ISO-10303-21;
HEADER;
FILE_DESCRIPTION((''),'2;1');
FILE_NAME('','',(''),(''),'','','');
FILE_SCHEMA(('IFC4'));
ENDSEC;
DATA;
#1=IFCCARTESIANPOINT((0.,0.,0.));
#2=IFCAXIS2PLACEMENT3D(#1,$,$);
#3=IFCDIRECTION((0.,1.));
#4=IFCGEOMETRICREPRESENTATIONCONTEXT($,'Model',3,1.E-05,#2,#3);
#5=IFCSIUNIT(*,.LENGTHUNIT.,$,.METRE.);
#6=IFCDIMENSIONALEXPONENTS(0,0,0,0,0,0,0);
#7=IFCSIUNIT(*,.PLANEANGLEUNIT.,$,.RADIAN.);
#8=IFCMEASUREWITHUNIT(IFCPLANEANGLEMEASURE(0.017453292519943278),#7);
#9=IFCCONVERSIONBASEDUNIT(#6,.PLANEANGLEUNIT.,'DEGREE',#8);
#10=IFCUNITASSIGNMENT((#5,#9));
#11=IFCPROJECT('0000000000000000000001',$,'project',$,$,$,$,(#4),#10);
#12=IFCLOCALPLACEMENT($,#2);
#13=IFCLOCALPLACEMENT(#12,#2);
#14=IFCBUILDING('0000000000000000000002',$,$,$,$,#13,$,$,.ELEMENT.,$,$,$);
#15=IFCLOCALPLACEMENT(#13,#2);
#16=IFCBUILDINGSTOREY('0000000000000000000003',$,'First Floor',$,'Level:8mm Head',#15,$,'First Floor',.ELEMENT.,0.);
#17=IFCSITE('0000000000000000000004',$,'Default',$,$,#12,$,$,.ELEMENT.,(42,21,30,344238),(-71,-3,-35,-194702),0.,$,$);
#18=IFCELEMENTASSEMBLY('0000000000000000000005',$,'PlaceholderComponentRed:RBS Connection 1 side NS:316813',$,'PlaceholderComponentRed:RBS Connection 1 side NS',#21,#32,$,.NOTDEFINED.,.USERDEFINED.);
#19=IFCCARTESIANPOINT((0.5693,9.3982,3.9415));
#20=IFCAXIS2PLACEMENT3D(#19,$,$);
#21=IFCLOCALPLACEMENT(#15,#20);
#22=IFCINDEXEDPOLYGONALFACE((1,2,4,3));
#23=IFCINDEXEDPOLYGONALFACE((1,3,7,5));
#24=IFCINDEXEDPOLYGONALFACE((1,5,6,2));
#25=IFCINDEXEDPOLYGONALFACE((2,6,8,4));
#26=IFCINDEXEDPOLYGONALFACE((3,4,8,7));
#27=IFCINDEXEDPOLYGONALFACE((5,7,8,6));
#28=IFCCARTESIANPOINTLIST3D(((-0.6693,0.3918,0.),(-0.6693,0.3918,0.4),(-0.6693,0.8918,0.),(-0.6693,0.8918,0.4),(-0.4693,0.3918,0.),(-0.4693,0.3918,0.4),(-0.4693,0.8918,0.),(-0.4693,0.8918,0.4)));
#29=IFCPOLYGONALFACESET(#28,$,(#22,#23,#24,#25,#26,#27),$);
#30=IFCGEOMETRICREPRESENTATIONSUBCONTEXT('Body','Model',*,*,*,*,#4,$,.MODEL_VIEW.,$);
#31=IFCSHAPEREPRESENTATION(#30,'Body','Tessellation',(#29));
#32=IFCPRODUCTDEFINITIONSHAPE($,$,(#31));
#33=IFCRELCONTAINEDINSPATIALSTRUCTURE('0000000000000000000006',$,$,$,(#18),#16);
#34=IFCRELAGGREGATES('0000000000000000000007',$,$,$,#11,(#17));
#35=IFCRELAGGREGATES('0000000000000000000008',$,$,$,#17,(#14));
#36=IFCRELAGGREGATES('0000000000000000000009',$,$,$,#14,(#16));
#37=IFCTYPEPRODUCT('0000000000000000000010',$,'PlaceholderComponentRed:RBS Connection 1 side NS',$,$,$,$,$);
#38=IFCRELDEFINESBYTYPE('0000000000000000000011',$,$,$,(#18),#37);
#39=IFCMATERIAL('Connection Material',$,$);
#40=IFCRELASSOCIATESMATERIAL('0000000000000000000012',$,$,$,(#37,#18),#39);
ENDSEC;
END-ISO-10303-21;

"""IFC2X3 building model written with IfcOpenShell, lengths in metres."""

from ifc_helpers import new_model, entity, si_unit, converted_unit, direction, frame, frame_2d, origin, place, context, subcontext, project, spatial, rectangle, extrude, source, transform, mapped, material, type_object, type_shapes, element, save


model = new_model("IFC2X3")

# Units and contexts
model_context = context("Model", 3, precision=1e-05, world=origin(), true_north=direction((0.0, 1.0)))
body_context = subcontext(model_context, "Body", "Model", "MODEL_VIEW")
ifc_project = project(units=[si_unit("LENGTHUNIT", "METRE"), converted_unit("PLANEANGLEUNIT", "DEGREE", entity("IfcPlaneAngleMeasure", 0.017453292519943278), si_unit("PLANEANGLEUNIT", "RADIAN"), dimensions=[0, 0, 0, 0, 0, 0, 0])], contexts=[model_context])

# Site, building, storey
site_placement = place(None, origin())
site = spatial("IfcSite", under=ifc_project, at=site_placement, Name="Default", CompositionType="ELEMENT", RefLatitude=(42, 21, 30, 344238), RefLongitude=(-71, -3, -35, -194702), RefElevation=0.0)
building_placement = place(site_placement, origin())
building = spatial("IfcBuilding", under=site, at=building_placement, CompositionType="ELEMENT")
storey_placement = place(building_placement, origin())
storey = spatial("IfcBuildingStorey", under=building, at=storey_placement, Name="First Floor", ObjectType="Level:8mm Head", LongName="First Floor", CompositionType="ELEMENT", Elevation=0.0)

# Element assembly
ifc_material = material(Name="Connection Material")
type_product = type_object("IfcTypeProduct", Name="PlaceholderComponentRed:RBS Connection 1 side NS", material=ifc_material)
shared_shape = source(origin(), body_context, "Body", "SweptSolid", [
    extrude(rectangle(XDim=0.5, YDim=0.2, at=frame_2d((0.0, 0.0), x_axis=(1.0, 0.0))), frame((-0.5693, 0.6418, 0.0), z_axis=(0.0, 0.0, 1.0), x_axis=(0.0, 1.0, 0.0)), (0.0, 0.0, 1.0), 0.4),
])
type_shapes(type_product, [shared_shape])
assembly_placement = place(storey_placement, frame((0.5693, 9.3982, 3.9415)))
element("IfcElementAssembly", 1, at=assembly_placement, inside=storey, type_object=type_product, material=ifc_material, Name="PlaceholderComponentRed:RBS Connection 1 side NS:316813", ObjectType="PlaceholderComponentRed:RBS Connection 1 side NS", AssemblyPlace="NOTDEFINED", PredefinedType="USERDEFINED", context=body_context, shape_type="MappedRepresentation", body=[
    mapped(shared_shape, transform((0.0, 0.0, 0.0), scale=1.0)),
])

save(model, "model.ifc")
